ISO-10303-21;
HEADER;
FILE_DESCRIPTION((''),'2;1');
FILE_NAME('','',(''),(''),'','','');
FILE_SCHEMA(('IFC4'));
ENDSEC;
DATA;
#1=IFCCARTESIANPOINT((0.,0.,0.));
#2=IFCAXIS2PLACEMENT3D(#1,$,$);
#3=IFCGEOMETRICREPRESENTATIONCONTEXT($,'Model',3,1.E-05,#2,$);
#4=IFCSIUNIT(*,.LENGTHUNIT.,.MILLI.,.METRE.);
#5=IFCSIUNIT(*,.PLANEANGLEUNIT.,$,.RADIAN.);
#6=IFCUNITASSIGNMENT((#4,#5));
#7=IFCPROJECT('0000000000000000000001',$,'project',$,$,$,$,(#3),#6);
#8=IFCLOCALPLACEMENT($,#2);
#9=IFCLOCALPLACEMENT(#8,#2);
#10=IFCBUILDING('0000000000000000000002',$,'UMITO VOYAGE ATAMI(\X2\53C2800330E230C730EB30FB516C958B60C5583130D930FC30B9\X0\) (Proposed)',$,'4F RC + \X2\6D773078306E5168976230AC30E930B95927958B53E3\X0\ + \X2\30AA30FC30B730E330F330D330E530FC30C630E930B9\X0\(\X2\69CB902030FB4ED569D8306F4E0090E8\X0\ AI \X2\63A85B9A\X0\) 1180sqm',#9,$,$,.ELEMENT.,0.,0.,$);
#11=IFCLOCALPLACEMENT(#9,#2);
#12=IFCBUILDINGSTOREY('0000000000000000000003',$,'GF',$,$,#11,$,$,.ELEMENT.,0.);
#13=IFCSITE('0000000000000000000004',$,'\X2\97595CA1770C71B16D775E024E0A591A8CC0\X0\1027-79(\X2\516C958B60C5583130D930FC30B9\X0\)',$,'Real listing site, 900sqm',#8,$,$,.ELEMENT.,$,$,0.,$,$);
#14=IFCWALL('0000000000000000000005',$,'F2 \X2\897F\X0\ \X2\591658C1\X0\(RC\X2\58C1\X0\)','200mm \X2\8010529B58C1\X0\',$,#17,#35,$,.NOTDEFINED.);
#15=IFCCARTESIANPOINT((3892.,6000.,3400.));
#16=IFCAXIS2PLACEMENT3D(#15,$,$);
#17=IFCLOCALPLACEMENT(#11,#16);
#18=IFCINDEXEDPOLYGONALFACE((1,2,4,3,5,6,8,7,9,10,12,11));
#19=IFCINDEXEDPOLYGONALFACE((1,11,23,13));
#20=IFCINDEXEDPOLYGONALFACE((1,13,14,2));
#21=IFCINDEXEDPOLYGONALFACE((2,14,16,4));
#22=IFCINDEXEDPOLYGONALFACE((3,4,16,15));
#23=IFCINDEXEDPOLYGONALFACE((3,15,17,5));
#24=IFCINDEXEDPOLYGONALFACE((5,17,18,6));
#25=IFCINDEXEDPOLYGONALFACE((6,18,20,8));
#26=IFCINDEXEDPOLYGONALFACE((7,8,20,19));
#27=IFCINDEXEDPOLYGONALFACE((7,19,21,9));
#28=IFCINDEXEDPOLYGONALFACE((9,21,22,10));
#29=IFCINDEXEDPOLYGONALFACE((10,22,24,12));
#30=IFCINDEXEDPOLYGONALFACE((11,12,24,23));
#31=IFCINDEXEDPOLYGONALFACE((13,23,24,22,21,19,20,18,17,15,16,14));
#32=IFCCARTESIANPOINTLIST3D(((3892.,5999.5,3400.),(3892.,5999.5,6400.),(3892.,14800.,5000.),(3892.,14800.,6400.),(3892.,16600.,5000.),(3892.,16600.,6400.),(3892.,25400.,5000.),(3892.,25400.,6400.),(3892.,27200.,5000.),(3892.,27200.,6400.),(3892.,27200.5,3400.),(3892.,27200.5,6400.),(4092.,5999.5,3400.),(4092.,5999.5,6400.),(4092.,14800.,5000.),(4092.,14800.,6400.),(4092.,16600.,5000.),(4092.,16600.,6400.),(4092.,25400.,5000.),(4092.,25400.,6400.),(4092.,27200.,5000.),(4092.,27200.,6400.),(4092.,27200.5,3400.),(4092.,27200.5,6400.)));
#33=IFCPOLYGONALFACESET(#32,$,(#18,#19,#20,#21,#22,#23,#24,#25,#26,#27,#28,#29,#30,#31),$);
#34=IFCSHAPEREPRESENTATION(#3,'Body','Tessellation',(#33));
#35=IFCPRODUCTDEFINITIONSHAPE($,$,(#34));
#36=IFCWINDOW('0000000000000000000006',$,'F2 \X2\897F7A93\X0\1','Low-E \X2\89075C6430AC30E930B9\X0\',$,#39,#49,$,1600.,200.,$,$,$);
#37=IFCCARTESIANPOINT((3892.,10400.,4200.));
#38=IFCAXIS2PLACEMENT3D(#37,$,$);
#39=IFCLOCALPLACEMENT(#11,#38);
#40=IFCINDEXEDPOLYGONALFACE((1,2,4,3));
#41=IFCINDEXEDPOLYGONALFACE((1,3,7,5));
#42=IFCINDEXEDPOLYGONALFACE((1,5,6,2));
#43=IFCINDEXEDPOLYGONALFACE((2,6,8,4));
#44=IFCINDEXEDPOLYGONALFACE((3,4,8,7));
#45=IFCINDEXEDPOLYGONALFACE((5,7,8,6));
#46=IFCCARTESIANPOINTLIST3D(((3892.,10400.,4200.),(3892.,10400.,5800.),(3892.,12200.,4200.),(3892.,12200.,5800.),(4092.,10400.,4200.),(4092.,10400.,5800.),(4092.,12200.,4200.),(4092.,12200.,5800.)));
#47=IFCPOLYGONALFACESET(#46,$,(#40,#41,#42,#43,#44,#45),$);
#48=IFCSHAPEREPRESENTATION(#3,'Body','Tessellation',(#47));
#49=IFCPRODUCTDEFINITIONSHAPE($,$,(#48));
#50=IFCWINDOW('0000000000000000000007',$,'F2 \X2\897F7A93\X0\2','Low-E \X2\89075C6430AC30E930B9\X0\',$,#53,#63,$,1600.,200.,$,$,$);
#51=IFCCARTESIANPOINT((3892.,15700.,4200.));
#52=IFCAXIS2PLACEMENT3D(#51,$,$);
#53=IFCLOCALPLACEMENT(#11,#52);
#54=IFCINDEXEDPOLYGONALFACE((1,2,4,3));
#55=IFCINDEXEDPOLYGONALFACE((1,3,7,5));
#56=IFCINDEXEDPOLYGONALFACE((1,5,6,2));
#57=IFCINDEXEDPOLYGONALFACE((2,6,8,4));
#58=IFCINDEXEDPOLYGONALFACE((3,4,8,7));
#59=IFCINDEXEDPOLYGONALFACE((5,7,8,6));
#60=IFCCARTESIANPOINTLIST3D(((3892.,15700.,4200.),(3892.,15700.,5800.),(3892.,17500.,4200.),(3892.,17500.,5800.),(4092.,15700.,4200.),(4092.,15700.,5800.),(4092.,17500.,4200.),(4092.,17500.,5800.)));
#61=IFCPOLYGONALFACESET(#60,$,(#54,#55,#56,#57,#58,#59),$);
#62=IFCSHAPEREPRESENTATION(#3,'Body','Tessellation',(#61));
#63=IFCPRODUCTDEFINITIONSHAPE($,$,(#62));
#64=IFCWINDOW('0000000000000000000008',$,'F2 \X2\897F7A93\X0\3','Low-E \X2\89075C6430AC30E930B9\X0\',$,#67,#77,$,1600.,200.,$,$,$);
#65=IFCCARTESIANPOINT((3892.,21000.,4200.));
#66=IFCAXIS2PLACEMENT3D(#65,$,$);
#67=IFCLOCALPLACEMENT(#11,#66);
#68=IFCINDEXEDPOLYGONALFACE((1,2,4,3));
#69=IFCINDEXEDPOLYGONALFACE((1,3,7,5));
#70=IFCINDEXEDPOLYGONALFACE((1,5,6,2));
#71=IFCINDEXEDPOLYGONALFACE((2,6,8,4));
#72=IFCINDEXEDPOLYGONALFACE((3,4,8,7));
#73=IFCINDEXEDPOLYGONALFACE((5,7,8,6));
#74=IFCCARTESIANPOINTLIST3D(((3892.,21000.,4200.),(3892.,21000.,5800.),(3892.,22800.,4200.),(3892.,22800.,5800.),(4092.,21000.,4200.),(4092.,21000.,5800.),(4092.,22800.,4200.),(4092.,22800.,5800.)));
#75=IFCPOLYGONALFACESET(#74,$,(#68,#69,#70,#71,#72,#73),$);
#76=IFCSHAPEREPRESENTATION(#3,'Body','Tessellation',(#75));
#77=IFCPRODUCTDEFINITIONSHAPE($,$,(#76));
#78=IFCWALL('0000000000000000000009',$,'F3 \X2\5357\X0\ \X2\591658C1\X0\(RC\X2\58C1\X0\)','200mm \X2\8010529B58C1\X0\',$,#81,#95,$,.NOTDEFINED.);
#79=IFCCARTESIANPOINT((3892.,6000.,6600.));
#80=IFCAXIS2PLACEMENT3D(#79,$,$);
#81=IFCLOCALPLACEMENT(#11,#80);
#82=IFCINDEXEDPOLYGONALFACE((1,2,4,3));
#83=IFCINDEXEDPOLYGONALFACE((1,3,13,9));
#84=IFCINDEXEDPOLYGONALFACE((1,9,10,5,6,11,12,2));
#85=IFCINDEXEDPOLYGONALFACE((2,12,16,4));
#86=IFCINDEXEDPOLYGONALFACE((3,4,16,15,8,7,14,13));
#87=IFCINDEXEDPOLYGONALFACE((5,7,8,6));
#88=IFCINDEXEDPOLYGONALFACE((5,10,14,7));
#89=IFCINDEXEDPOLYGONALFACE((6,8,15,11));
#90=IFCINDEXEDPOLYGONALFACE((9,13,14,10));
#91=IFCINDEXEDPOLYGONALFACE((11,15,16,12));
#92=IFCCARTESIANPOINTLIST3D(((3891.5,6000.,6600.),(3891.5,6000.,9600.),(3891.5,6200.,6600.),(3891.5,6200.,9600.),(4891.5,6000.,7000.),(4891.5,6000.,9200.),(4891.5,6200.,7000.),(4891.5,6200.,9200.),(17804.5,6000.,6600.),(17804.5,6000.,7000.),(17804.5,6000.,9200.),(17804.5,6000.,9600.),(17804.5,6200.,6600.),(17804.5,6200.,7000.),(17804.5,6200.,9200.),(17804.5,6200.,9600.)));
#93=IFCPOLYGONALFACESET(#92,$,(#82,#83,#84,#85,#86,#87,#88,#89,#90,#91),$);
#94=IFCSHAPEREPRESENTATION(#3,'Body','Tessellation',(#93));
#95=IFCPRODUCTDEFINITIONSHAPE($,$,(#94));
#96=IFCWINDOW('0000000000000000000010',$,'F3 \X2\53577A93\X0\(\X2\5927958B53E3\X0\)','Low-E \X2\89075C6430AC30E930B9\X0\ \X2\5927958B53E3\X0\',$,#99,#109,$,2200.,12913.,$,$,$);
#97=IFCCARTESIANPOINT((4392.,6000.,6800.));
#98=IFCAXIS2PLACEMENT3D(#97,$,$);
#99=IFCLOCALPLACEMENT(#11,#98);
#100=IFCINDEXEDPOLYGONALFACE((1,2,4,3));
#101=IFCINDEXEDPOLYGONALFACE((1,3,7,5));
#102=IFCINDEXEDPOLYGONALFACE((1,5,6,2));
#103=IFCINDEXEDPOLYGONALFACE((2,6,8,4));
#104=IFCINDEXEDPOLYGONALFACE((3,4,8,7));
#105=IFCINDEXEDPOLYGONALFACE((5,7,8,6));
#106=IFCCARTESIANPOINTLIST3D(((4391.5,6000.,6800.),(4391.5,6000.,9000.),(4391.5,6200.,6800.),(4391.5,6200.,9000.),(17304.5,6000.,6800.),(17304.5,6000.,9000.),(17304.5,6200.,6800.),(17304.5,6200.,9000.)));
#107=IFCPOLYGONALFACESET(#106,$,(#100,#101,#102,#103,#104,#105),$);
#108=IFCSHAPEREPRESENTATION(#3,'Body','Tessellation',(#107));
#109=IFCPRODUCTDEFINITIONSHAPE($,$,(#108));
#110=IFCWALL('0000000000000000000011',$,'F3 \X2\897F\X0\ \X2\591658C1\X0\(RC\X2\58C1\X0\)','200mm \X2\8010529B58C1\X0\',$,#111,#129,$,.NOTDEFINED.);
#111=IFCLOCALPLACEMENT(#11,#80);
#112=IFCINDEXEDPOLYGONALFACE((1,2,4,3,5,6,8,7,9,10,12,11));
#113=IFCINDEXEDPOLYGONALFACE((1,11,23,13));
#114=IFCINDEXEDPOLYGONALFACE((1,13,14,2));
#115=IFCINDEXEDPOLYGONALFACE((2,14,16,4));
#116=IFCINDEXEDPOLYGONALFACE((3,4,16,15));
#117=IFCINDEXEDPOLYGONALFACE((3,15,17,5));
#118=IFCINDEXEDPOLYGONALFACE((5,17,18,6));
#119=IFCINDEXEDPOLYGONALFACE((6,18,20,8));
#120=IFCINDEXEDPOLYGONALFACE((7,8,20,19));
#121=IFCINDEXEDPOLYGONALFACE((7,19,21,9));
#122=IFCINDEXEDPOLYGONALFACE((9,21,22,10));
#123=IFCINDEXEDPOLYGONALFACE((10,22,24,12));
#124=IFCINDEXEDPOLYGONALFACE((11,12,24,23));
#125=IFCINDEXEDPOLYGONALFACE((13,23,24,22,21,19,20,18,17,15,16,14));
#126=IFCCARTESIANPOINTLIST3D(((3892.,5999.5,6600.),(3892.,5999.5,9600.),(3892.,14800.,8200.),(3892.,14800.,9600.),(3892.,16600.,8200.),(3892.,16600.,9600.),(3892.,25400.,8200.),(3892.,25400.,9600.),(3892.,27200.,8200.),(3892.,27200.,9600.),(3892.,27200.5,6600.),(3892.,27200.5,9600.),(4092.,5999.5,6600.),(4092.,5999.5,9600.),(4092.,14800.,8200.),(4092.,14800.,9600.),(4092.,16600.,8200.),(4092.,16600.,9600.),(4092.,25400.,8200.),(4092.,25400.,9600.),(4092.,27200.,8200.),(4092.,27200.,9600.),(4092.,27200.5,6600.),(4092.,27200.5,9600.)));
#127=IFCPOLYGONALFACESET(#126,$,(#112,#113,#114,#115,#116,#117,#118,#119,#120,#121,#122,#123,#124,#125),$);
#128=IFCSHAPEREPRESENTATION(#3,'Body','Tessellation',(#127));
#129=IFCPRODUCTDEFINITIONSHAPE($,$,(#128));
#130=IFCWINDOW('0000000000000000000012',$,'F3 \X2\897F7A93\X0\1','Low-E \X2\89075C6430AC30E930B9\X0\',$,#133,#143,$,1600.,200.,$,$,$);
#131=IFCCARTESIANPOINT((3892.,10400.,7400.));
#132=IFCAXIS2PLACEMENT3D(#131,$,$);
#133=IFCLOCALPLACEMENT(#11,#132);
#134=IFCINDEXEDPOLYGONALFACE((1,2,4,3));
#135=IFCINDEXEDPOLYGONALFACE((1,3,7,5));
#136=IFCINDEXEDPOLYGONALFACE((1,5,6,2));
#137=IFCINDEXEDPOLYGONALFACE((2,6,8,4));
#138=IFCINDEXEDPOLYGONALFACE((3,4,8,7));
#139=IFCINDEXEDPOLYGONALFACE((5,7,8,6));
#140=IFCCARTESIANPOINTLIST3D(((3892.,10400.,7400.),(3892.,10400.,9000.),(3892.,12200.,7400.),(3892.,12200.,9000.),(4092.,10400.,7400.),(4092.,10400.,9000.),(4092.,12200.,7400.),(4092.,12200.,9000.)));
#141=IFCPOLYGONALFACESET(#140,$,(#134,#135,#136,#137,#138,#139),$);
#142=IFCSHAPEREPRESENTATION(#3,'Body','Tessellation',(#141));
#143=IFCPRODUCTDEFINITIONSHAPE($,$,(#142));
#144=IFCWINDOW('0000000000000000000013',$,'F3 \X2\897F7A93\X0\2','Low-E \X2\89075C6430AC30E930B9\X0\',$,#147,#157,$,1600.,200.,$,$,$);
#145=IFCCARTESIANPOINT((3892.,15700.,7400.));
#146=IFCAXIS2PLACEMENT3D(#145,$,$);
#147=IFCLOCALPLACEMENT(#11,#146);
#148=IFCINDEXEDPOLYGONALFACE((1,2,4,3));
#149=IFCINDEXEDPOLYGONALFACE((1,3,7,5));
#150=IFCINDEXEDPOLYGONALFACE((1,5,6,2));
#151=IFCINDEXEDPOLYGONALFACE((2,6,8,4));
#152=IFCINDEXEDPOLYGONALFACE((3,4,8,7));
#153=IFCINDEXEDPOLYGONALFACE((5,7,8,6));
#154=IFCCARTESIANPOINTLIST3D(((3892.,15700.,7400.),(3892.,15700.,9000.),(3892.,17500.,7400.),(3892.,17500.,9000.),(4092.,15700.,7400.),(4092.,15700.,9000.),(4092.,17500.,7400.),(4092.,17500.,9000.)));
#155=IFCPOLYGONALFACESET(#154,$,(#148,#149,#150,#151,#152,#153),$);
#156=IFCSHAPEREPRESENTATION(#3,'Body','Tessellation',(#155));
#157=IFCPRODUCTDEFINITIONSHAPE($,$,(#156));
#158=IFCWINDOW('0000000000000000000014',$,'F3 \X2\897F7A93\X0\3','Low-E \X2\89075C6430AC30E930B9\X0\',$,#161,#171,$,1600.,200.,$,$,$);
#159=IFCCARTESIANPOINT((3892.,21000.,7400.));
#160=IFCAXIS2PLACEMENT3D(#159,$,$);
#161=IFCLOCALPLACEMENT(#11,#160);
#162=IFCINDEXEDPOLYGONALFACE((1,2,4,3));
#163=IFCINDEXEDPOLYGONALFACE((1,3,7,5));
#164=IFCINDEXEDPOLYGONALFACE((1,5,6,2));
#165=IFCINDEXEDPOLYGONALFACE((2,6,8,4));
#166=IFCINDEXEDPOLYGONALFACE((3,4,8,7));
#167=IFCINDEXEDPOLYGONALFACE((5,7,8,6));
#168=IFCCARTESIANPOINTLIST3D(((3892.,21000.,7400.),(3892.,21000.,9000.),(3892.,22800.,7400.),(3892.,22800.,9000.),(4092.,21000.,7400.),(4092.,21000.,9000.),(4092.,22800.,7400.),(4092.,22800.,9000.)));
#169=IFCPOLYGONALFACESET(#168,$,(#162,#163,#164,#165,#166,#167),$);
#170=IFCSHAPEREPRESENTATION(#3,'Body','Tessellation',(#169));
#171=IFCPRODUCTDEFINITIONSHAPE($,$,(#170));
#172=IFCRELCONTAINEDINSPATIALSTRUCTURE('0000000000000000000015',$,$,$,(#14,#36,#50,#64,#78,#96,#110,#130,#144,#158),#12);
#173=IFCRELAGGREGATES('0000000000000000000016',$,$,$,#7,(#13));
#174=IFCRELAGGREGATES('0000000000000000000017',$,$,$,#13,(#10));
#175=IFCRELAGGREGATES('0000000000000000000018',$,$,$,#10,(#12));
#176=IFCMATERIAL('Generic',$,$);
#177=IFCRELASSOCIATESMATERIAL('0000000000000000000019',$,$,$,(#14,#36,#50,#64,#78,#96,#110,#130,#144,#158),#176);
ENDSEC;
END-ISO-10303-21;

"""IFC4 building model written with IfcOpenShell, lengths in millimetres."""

from ifc_helpers import new_model, si_unit, frame, frame_2d, origin, place, context, project, spatial, rectangle, extrude, material, element, fill, save


model = new_model("IFC4")

# Units and contexts
model_context = context("Model", 3, precision=1e-05, world=origin())
ifc_project = project(units=[si_unit("LENGTHUNIT", "METRE", prefix="MILLI"), si_unit("PLANEANGLEUNIT", "RADIAN")], contexts=[model_context])

# Site, building, storey
site_placement = place(None, origin())
site = spatial("IfcSite", under=ifc_project, at=site_placement, Name="静岡県熱海市上多賀1027-79(公開情報ベース)", ObjectType="Real listing site, 900sqm", CompositionType="ELEMENT", RefElevation=0.0)
building_placement = place(site_placement, origin())
building = spatial("IfcBuilding", under=site, at=building_placement, Name="UMITO VOYAGE ATAMI(参考モデル・公開情報ベース) (Proposed)", ObjectType="4F RC + 海への全面ガラス大開口 + オーシャンビューテラス(構造・仕様は一部 AI 推定) 1180sqm", CompositionType="ELEMENT", ElevationOfRefHeight=0.0, ElevationOfTerrain=0.0)
storey_placement = place(building_placement, origin())
storey = spatial("IfcBuildingStorey", under=building, at=storey_placement, Name="GF", CompositionType="ELEMENT", Elevation=0.0)

# Wall, openings, windows
ifc_material_1 = material(Name="Generic")
wall_1_placement = place(storey_placement, frame((3892.0, 6000.0, 3400.0)))
wall_1 = element("IfcWall", 1, at=wall_1_placement, inside=storey, material=ifc_material_1, Name="F2 西 外壁(RC壁)", Description="200mm 耐力壁", PredefinedType="NOTDEFINED", context=model_context, shape_type="SweptSolid", body=[
    extrude(rectangle(XDim=200.0, YDim=21201.0, at=frame_2d((100.0, 10600.0))), frame((3892.0, 6000.0, 3400.0)), (0.0, 0.0, 1.0), 3000.0),
])
opening_1_placement = place(storey_placement, frame((3892.0, 10400.0, 4200.0)))
opening_1 = element("IfcOpeningElement", 2, at=opening_1_placement, cuts=wall_1, PredefinedType="NOTDEFINED", context=model_context, shape_type="SweptSolid", body=[
    extrude(rectangle(XDim=200.0, YDim=1800.0, at=frame_2d((100.0, 900.0))), frame((3892.0, 10400.0, 4200.0)), (0.0, 0.0, 1.0), 1600.0),
])
opening_2_placement = place(storey_placement, frame((3892.0, 15700.0, 4200.0)))
opening_2 = element("IfcOpeningElement", 3, at=opening_2_placement, cuts=wall_1, PredefinedType="NOTDEFINED", context=model_context, shape_type="SweptSolid", body=[
    extrude(rectangle(XDim=200.0, YDim=1800.0, at=frame_2d((100.0, 900.0))), frame((3892.0, 15700.0, 4200.0)), (0.0, 0.0, 1.0), 1600.0),
])
opening_3_placement = place(storey_placement, frame((3892.0, 21000.0, 4200.0)))
opening_3 = element("IfcOpeningElement", 4, at=opening_3_placement, cuts=wall_1, PredefinedType="NOTDEFINED", context=model_context, shape_type="SweptSolid", body=[
    extrude(rectangle(XDim=200.0, YDim=1800.0, at=frame_2d((100.0, 900.0))), frame((3892.0, 21000.0, 4200.0)), (0.0, 0.0, 1.0), 1600.0),
])
window_1_placement = place(storey_placement, frame((3892.0, 10400.0, 4200.0)))
window_1 = element("IfcWindow", 5, at=window_1_placement, inside=storey, material=ifc_material_1, Name="F2 西窓1", Description="Low-E 複層ガラス", OverallHeight=1600.0, OverallWidth=200.0, context=model_context, shape_type="SweptSolid", body=[
    extrude(rectangle(XDim=200.0, YDim=1800.0, at=frame_2d((100.0, 900.0))), frame((3892.0, 10400.0, 4200.0)), (0.0, 0.0, 1.0), 1600.0),
])
fill(opening_1, window_1)
window_2_placement = place(storey_placement, frame((3892.0, 15700.0, 4200.0)))
window_2 = element("IfcWindow", 6, at=window_2_placement, inside=storey, material=ifc_material_1, Name="F2 西窓2", Description="Low-E 複層ガラス", OverallHeight=1600.0, OverallWidth=200.0, context=model_context, shape_type="SweptSolid", body=[
    extrude(rectangle(XDim=200.0, YDim=1800.0, at=frame_2d((100.0, 900.0))), frame((3892.0, 15700.0, 4200.0)), (0.0, 0.0, 1.0), 1600.0),
])
fill(opening_2, window_2)
window_3_placement = place(storey_placement, frame((3892.0, 21000.0, 4200.0)))
window_3 = element("IfcWindow", 7, at=window_3_placement, inside=storey, material=ifc_material_1, Name="F2 西窓3", Description="Low-E 複層ガラス", OverallHeight=1600.0, OverallWidth=200.0, context=model_context, shape_type="SweptSolid", body=[
    extrude(rectangle(XDim=200.0, YDim=1800.0, at=frame_2d((100.0, 900.0))), frame((3892.0, 21000.0, 4200.0)), (0.0, 0.0, 1.0), 1600.0),
])
fill(opening_3, window_3)

# Wall, opening, window
wall_2_placement = place(storey_placement, frame((3892.0, 6000.0, 6600.0)))
wall_2 = element("IfcWall", 8, at=wall_2_placement, inside=storey, material=ifc_material_1, Name="F3 南 外壁(RC壁)", Description="200mm 耐力壁", PredefinedType="NOTDEFINED", context=model_context, shape_type="SweptSolid", body=[
    extrude(rectangle(XDim=13913.0, YDim=200.0, at=frame_2d((6956.0, 100.0))), frame((3892.0, 6000.0, 6600.0)), (0.0, 0.0, 1.0), 3000.0),
])
opening_4_placement = place(storey_placement, frame((4392.0, 6000.0, 6800.0)))
opening_4 = element("IfcOpeningElement", 9, at=opening_4_placement, cuts=wall_2, PredefinedType="NOTDEFINED", context=model_context, shape_type="SweptSolid", body=[
    extrude(rectangle(XDim=12913.0, YDim=200.0, at=frame_2d((6456.0, 100.0))), frame((4392.0, 6000.0, 6800.0)), (0.0, 0.0, 1.0), 2200.0),
])
window_4_placement = place(storey_placement, frame((4392.0, 6000.0, 6800.0)))
window_4 = element("IfcWindow", 10, at=window_4_placement, inside=storey, material=ifc_material_1, Name="F3 南窓(大開口)", Description="Low-E 複層ガラス 大開口", OverallHeight=2200.0, OverallWidth=12913.0, context=model_context, shape_type="SweptSolid", body=[
    extrude(rectangle(XDim=12913.0, YDim=200.0, at=frame_2d((6456.0, 100.0))), frame((4392.0, 6000.0, 6800.0)), (0.0, 0.0, 1.0), 2200.0),
])
fill(opening_4, window_4)

# Wall, openings, windows
wall_3_placement = place(storey_placement, frame((3892.0, 6000.0, 6600.0)))
wall_3 = element("IfcWall", 11, at=wall_3_placement, inside=storey, material=ifc_material_1, Name="F3 西 外壁(RC壁)", Description="200mm 耐力壁", PredefinedType="NOTDEFINED", context=model_context, shape_type="SweptSolid", body=[
    extrude(rectangle(XDim=200.0, YDim=21201.0, at=frame_2d((100.0, 10600.0))), frame((3892.0, 6000.0, 6600.0)), (0.0, 0.0, 1.0), 3000.0),
])
opening_5_placement = place(storey_placement, frame((3892.0, 10400.0, 7400.0)))
opening_5 = element("IfcOpeningElement", 12, at=opening_5_placement, cuts=wall_3, PredefinedType="NOTDEFINED", context=model_context, shape_type="SweptSolid", body=[
    extrude(rectangle(XDim=200.0, YDim=1800.0, at=frame_2d((100.0, 900.0))), frame((3892.0, 10400.0, 7400.0)), (0.0, 0.0, 1.0), 1600.0),
])
opening_6_placement = place(storey_placement, frame((3892.0, 15700.0, 7400.0)))
opening_6 = element("IfcOpeningElement", 13, at=opening_6_placement, cuts=wall_3, PredefinedType="NOTDEFINED", context=model_context, shape_type="SweptSolid", body=[
    extrude(rectangle(XDim=200.0, YDim=1800.0, at=frame_2d((100.0, 900.0))), frame((3892.0, 15700.0, 7400.0)), (0.0, 0.0, 1.0), 1600.0),
])
opening_7_placement = place(storey_placement, frame((3892.0, 21000.0, 7400.0)))
opening_7 = element("IfcOpeningElement", 14, at=opening_7_placement, cuts=wall_3, PredefinedType="NOTDEFINED", context=model_context, shape_type="SweptSolid", body=[
    extrude(rectangle(XDim=200.0, YDim=1800.0, at=frame_2d((100.0, 900.0))), frame((3892.0, 21000.0, 7400.0)), (0.0, 0.0, 1.0), 1600.0),
])
window_5_placement = place(storey_placement, frame((3892.0, 10400.0, 7400.0)))
window_5 = element("IfcWindow", 15, at=window_5_placement, inside=storey, material=ifc_material_1, Name="F3 西窓1", Description="Low-E 複層ガラス", OverallHeight=1600.0, OverallWidth=200.0, context=model_context, shape_type="SweptSolid", body=[
    extrude(rectangle(XDim=200.0, YDim=1800.0, at=frame_2d((100.0, 900.0))), frame((3892.0, 10400.0, 7400.0)), (0.0, 0.0, 1.0), 1600.0),
])
fill(opening_5, window_5)
window_6_placement = place(storey_placement, frame((3892.0, 15700.0, 7400.0)))
window_6 = element("IfcWindow", 16, at=window_6_placement, inside=storey, material=ifc_material_1, Name="F3 西窓2", Description="Low-E 複層ガラス", OverallHeight=1600.0, OverallWidth=200.0, context=model_context, shape_type="SweptSolid", body=[
    extrude(rectangle(XDim=200.0, YDim=1800.0, at=frame_2d((100.0, 900.0))), frame((3892.0, 15700.0, 7400.0)), (0.0, 0.0, 1.0), 1600.0),
])
fill(opening_6, window_6)
window_7_placement = place(storey_placement, frame((3892.0, 21000.0, 7400.0)))
window_7 = element("IfcWindow", 17, at=window_7_placement, inside=storey, material=ifc_material_1, Name="F3 西窓3", Description="Low-E 複層ガラス", OverallHeight=1600.0, OverallWidth=200.0, context=model_context, shape_type="SweptSolid", body=[
    extrude(rectangle(XDim=200.0, YDim=1800.0, at=frame_2d((100.0, 900.0))), frame((3892.0, 21000.0, 7400.0)), (0.0, 0.0, 1.0), 1600.0),
])
fill(opening_7, window_7)

save(model, "model.ifc")
